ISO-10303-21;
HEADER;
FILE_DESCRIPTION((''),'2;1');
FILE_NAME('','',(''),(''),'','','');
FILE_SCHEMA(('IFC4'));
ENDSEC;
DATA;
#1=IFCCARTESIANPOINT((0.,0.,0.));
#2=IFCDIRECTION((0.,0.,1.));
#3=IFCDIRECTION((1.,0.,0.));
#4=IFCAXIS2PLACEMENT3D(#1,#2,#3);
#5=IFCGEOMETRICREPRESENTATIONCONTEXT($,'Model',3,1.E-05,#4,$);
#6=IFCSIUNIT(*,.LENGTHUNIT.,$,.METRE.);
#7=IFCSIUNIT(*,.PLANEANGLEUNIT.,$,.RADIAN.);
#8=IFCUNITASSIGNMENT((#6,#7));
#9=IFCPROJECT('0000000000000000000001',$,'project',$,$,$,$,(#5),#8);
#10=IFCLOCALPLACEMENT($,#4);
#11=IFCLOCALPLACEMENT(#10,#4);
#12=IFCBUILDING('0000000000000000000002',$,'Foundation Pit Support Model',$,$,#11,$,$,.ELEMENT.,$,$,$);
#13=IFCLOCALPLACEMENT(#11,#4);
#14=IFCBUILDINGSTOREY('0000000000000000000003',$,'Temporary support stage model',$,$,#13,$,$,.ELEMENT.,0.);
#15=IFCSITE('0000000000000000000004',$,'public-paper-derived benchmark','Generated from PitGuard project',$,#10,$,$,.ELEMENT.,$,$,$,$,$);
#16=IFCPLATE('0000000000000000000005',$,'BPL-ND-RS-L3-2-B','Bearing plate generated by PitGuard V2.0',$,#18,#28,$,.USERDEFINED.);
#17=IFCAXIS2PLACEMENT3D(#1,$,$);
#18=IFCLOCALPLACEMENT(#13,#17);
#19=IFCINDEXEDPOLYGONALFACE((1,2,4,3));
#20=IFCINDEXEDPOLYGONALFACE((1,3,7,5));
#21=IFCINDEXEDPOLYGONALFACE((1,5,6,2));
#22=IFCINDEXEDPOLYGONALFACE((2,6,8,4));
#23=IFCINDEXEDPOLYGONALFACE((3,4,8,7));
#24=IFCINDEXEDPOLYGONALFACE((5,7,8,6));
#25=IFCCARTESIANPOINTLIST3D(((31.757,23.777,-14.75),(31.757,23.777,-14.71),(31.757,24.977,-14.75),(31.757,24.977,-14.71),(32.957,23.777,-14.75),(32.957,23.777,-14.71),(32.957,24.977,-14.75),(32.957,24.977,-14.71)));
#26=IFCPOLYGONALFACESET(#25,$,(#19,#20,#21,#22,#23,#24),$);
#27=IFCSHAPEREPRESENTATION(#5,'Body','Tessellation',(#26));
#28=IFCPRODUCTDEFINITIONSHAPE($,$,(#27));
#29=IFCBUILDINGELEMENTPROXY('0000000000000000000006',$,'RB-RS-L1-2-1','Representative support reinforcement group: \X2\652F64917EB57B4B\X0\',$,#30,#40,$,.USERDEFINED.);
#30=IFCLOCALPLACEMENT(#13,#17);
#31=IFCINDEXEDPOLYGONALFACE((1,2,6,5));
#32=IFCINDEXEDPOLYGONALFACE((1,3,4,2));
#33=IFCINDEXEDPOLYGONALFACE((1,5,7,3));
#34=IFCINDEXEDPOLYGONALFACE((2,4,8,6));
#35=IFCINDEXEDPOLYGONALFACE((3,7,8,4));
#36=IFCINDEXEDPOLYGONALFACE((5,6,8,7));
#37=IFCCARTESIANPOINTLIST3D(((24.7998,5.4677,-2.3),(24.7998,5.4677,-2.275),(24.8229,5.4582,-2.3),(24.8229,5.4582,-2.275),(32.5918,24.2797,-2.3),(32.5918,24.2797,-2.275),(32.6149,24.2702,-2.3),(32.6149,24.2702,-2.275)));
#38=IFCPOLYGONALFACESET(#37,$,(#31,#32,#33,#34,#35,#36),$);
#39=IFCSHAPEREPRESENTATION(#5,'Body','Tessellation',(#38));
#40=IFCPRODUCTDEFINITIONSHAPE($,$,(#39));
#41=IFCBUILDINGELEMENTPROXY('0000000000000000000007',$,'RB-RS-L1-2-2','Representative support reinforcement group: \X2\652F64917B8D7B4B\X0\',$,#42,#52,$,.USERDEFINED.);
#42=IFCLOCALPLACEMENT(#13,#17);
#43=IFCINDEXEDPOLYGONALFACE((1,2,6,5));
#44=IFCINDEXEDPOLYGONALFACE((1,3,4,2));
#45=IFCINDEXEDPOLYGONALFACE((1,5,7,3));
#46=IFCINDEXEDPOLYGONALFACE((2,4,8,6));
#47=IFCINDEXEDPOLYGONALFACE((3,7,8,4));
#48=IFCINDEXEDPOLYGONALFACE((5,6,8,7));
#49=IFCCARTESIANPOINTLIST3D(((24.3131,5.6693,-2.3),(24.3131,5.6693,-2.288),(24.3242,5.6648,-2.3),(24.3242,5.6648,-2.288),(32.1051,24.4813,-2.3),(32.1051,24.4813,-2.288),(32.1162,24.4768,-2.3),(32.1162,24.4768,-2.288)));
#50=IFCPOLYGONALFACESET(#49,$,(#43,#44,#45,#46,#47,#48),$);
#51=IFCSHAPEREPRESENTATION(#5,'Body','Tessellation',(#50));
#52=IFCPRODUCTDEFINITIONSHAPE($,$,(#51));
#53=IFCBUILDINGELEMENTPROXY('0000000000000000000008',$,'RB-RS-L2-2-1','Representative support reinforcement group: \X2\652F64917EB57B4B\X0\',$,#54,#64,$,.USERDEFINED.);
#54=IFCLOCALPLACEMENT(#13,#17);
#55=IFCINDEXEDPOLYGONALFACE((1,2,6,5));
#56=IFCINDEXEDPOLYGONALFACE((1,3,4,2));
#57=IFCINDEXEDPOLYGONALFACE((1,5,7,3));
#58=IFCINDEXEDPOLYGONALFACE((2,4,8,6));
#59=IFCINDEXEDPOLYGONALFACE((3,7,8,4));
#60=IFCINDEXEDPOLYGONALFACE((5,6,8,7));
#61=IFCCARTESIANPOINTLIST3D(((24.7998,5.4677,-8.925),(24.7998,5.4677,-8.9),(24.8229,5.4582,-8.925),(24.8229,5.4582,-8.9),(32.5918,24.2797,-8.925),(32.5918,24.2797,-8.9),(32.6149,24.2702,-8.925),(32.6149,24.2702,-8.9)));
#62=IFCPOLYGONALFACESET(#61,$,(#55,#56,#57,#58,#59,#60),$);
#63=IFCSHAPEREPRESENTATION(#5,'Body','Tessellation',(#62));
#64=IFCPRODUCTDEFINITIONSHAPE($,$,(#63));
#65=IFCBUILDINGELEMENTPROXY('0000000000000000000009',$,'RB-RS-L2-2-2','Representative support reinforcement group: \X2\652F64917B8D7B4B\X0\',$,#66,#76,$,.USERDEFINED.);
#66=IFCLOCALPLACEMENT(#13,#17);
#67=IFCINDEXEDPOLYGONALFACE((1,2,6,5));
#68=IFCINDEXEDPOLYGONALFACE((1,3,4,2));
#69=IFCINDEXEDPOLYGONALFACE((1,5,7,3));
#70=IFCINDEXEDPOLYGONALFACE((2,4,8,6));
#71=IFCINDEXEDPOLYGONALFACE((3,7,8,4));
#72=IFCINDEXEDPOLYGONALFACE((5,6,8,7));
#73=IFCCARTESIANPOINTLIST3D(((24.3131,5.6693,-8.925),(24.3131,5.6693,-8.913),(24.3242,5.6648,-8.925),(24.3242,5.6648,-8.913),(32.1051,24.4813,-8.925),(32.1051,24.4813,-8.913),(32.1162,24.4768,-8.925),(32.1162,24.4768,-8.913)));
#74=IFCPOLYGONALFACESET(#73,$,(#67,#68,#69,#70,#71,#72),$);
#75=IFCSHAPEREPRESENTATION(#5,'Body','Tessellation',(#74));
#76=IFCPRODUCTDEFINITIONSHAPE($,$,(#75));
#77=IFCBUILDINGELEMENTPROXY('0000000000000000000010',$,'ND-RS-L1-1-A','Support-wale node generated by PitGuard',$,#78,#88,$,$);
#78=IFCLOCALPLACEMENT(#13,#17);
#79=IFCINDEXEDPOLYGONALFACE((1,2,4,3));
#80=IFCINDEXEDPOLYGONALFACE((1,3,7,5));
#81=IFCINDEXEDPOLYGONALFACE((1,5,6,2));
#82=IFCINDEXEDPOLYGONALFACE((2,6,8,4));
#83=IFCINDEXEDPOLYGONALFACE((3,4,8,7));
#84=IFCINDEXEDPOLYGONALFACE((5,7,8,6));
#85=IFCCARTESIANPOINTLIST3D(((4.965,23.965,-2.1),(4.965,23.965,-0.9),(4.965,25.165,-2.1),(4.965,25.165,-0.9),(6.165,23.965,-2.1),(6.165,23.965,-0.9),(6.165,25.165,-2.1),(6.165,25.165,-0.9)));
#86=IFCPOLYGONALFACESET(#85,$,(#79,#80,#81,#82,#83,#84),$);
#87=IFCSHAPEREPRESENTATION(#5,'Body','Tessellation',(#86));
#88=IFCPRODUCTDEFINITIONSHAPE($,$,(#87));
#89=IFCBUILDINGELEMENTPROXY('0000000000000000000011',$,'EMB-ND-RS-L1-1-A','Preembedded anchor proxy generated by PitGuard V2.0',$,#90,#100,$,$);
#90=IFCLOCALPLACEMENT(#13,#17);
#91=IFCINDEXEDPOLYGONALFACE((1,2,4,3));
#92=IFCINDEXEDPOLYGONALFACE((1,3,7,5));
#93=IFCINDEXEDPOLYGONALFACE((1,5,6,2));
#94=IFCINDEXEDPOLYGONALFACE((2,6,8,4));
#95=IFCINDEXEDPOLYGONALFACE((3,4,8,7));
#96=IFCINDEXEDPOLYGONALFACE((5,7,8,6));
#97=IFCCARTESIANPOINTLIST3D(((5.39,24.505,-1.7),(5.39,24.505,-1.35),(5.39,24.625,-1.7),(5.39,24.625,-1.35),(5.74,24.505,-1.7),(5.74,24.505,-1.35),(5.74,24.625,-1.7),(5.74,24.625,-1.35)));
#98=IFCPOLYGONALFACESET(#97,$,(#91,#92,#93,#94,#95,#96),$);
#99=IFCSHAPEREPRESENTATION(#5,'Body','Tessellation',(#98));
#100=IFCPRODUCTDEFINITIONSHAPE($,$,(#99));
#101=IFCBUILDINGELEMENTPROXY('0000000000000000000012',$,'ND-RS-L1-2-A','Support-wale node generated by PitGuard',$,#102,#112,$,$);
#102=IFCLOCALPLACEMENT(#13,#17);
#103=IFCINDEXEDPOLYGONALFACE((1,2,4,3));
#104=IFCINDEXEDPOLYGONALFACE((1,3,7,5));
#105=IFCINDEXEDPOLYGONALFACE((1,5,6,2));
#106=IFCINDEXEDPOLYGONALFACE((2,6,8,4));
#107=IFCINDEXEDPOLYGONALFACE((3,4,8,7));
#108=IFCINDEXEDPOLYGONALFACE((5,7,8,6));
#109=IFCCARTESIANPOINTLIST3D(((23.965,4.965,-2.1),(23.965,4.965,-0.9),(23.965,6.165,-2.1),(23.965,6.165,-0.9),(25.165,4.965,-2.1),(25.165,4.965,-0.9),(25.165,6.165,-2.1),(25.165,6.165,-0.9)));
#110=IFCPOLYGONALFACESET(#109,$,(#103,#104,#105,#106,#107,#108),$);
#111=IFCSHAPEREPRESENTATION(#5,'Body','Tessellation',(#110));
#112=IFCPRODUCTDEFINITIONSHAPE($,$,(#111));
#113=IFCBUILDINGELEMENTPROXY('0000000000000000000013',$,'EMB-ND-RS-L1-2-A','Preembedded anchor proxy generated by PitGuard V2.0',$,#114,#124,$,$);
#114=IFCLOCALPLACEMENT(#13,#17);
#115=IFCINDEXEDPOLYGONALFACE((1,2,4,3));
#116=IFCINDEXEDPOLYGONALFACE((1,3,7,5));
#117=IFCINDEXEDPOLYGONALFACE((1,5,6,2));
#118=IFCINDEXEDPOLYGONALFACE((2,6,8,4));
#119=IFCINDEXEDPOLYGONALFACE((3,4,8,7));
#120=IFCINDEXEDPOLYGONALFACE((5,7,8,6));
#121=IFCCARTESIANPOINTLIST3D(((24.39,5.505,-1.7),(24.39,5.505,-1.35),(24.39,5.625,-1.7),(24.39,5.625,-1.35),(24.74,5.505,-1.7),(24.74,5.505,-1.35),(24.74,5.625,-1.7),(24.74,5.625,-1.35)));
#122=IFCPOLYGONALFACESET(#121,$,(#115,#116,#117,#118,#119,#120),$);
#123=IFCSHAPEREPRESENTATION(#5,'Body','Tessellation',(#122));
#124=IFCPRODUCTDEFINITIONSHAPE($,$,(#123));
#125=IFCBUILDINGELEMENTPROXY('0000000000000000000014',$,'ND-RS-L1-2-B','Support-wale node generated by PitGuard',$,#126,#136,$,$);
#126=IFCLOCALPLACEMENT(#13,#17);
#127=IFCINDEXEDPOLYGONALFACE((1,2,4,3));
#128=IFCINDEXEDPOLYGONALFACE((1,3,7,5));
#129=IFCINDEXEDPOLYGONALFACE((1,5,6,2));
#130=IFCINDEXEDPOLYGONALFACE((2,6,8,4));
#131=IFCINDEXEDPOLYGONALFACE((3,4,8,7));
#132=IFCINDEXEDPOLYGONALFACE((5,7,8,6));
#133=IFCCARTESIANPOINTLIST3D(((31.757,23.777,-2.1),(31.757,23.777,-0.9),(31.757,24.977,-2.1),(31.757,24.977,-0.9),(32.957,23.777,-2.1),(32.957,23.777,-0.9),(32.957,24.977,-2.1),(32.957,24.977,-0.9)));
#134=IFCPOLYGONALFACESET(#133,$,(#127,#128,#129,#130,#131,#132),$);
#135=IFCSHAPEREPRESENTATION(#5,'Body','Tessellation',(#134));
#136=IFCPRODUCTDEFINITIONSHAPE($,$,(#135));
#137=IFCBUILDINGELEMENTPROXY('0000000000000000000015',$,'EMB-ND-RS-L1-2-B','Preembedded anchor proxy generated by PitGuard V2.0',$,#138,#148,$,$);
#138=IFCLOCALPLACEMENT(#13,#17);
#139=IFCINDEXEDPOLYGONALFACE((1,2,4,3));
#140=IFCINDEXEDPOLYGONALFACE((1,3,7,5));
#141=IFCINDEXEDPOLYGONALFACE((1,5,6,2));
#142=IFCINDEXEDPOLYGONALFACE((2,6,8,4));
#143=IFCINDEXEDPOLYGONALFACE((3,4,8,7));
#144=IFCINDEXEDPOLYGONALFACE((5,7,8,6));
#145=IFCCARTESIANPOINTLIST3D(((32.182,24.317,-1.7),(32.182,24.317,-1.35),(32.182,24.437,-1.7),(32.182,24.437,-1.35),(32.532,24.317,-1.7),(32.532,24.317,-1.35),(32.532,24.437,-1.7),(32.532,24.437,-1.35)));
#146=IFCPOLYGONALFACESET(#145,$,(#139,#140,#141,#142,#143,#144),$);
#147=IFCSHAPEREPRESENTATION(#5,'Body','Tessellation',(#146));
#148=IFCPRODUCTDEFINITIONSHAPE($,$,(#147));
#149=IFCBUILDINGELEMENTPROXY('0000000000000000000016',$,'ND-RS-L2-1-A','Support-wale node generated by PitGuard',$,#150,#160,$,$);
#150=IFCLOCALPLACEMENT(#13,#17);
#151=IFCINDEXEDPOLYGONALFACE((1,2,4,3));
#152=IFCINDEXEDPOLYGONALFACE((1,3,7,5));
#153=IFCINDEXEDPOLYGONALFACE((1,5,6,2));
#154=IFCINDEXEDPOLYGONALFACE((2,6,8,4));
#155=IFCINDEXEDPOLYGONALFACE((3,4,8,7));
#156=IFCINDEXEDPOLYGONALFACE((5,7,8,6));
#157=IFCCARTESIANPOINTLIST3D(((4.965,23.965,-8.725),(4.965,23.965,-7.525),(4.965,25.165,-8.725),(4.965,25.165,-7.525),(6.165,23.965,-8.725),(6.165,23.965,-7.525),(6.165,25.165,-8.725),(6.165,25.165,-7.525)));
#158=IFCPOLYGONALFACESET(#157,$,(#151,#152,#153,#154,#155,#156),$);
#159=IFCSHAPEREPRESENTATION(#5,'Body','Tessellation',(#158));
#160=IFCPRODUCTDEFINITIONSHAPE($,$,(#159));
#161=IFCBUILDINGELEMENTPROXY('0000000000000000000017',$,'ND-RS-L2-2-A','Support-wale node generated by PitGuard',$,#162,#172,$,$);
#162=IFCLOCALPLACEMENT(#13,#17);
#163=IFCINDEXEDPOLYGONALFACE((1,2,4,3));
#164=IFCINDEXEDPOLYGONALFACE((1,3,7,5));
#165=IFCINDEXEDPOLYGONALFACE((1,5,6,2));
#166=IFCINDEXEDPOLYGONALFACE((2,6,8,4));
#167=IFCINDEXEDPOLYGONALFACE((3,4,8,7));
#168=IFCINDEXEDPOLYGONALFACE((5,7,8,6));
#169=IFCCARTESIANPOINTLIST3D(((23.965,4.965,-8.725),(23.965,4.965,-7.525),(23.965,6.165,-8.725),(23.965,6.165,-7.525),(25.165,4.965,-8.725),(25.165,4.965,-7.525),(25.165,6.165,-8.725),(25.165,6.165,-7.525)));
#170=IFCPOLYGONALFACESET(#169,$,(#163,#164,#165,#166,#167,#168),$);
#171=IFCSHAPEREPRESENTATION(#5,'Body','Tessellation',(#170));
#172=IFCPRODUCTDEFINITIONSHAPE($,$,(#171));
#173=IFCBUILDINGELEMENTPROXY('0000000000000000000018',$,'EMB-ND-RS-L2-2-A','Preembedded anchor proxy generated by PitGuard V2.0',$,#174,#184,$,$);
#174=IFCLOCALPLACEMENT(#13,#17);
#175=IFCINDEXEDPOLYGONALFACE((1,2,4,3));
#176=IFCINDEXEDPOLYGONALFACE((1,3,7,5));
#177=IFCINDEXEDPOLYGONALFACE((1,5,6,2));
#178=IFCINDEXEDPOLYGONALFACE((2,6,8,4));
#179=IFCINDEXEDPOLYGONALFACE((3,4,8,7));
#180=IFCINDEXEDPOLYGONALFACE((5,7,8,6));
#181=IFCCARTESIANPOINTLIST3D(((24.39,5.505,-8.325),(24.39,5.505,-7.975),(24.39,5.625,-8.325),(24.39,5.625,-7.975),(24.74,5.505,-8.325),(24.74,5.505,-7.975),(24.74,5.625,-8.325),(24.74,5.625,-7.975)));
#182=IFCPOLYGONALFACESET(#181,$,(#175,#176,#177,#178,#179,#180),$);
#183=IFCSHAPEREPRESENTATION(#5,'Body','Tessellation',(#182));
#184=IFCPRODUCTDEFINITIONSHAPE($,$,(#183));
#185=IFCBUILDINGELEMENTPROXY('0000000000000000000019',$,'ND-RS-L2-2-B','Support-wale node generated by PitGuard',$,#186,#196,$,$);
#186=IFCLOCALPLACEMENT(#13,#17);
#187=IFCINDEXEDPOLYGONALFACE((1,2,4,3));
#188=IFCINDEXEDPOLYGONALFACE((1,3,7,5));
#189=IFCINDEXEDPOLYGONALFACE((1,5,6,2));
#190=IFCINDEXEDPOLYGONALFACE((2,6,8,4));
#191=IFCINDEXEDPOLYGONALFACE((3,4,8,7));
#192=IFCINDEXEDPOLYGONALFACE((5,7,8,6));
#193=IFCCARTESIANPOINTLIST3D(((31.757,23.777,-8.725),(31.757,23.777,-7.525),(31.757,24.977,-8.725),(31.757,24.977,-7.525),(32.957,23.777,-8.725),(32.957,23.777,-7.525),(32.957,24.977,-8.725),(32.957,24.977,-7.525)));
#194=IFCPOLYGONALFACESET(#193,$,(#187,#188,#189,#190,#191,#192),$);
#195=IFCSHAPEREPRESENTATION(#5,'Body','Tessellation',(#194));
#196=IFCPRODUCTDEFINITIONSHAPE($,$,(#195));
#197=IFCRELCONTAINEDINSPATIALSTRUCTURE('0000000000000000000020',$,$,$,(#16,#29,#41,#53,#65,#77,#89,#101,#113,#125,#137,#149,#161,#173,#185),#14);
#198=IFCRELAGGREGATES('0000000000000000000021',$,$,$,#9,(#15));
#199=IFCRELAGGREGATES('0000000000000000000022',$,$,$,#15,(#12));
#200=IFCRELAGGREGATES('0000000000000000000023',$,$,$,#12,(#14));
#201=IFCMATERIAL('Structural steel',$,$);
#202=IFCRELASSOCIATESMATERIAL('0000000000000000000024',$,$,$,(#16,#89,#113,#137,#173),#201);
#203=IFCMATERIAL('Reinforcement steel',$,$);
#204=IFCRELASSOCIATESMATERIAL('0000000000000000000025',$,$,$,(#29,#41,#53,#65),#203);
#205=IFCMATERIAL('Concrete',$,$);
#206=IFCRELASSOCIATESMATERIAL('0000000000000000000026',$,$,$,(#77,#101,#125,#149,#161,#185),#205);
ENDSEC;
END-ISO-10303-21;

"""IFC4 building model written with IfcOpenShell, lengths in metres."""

from ifc_helpers import new_model, si_unit, frame, origin_with_axes, origin_2d, place, context, project, spatial, rectangle, extrude, material, element, save


model = new_model("IFC4")

# Units and contexts
model_context = context("Model", 3, precision=1e-05, world=origin_with_axes())
ifc_project = project(units=[si_unit("LENGTHUNIT", "METRE"), si_unit("PLANEANGLEUNIT", "RADIAN")], contexts=[model_context])

# Site, building, storey
site_placement = place(None, origin_with_axes())
site = spatial("IfcSite", under=ifc_project, at=site_placement, Name="public-paper-derived benchmark", Description="Generated from PitGuard project", CompositionType="ELEMENT")
building_placement = place(site_placement, origin_with_axes())
building = spatial("IfcBuilding", under=site, at=building_placement, Name="Foundation Pit Support Model", CompositionType="ELEMENT")
storey_placement = place(building_placement, origin_with_axes())
storey = spatial("IfcBuildingStorey", under=building, at=storey_placement, Name="Temporary support stage model", CompositionType="ELEMENT", Elevation=0.0)

# Shared definitions
ifc_material_1 = material(Name="Concrete")

# Plate
ifc_material_2 = material(Name="Structural steel")
for number, where, z_axis, x_axis, name in (
    (1, (32.357, 24.377, -14.75), (0.0, 0.0, 1.0), (1.0, 0.0, 0.0), "BPL-ND-RS-L3-2-B"),
):
    element("IfcPlate", number, at=place(storey_placement, frame(where, z_axis=z_axis, x_axis=x_axis)), inside=storey, material=ifc_material_2, Name=name, Description="Bearing plate generated by PitGuard V2.0", PredefinedType="USERDEFINED", context=model_context, shape_type="SweptSolid", body=[
        extrude(rectangle(XDim=1.2, YDim=1.2, at=origin_2d()), origin_with_axes(), (0.0, 0.0, 1.0), 0.04),
    ])

# Building element proxies
ifc_material_3 = material(Name="Reinforcement steel")
proxy_1_placement = place(storey_placement, frame((28.7074, 14.869, -2.3), z_axis=(0.0, 0.0, 1.0), x_axis=(0.382676, 0.923883, 0.0)))
element("IfcBuildingElementProxy", 2, at=proxy_1_placement, inside=storey, material=ifc_material_3, Name="RB-RS-L1-2-1", Description="Representative support reinforcement group: 支撑纵筋", PredefinedType="USERDEFINED", context=model_context, shape_type="SweptSolid", body=[
    extrude(rectangle(XDim=20.3619, YDim=0.025, at=origin_2d()), origin_with_axes(), (0.0, 0.0, 1.0), 0.025),
])
proxy_2_placement = place(storey_placement, frame((28.2146, 15.073, -2.3), z_axis=(0.0, 0.0, 1.0), x_axis=(0.382676, 0.923883, 0.0)))
element("IfcBuildingElementProxy", 3, at=proxy_2_placement, inside=storey, material=ifc_material_3, Name="RB-RS-L1-2-2", Description="Representative support reinforcement group: 支撑箍筋", PredefinedType="USERDEFINED", context=model_context, shape_type="SweptSolid", body=[
    extrude(rectangle(XDim=20.3619, YDim=0.012, at=origin_2d()), origin_with_axes(), (0.0, 0.0, 1.0), 0.012),
])
proxy_3_placement = place(storey_placement, frame((28.7074, 14.869, -8.925), z_axis=(0.0, 0.0, 1.0), x_axis=(0.382676, 0.923883, 0.0)))
element("IfcBuildingElementProxy", 4, at=proxy_3_placement, inside=storey, material=ifc_material_3, Name="RB-RS-L2-2-1", Description="Representative support reinforcement group: 支撑纵筋", PredefinedType="USERDEFINED", context=model_context, shape_type="SweptSolid", body=[
    extrude(rectangle(XDim=20.3619, YDim=0.025, at=origin_2d()), origin_with_axes(), (0.0, 0.0, 1.0), 0.025),
])
proxy_4_placement = place(storey_placement, frame((28.2146, 15.073, -8.925), z_axis=(0.0, 0.0, 1.0), x_axis=(0.382676, 0.923883, 0.0)))
element("IfcBuildingElementProxy", 5, at=proxy_4_placement, inside=storey, material=ifc_material_3, Name="RB-RS-L2-2-2", Description="Representative support reinforcement group: 支撑箍筋", PredefinedType="USERDEFINED", context=model_context, shape_type="SweptSolid", body=[
    extrude(rectangle(XDim=20.3619, YDim=0.012, at=origin_2d()), origin_with_axes(), (0.0, 0.0, 1.0), 0.012),
])
proxy_5_placement = place(storey_placement, frame((5.565, 24.565, -2.1), z_axis=(0.0, 0.0, 1.0), x_axis=(1.0, 0.0, 0.0)))
element("IfcBuildingElementProxy", 6, at=proxy_5_placement, inside=storey, material=ifc_material_1, Name="ND-RS-L1-1-A", Description="Support-wale node generated by PitGuard", context=model_context, shape_type="SweptSolid", body=[
    extrude(rectangle(XDim=1.2, YDim=1.2, at=origin_2d()), origin_with_axes(), (0.0, 0.0, 1.0), 1.2),
])
proxy_6_placement = place(storey_placement, frame((5.565, 24.565, -1.7), z_axis=(0.0, 0.0, 1.0), x_axis=(1.0, 0.0, 0.0)))
element("IfcBuildingElementProxy", 7, at=proxy_6_placement, inside=storey, material=ifc_material_2, Name="EMB-ND-RS-L1-1-A", Description="Preembedded anchor proxy generated by PitGuard V2.0", context=model_context, shape_type="SweptSolid", body=[
    extrude(rectangle(XDim=0.35, YDim=0.12, at=origin_2d()), origin_with_axes(), (0.0, 0.0, 1.0), 0.35),
])
proxy_7_placement = place(storey_placement, frame((24.565, 5.565, -2.1), z_axis=(0.0, 0.0, 1.0), x_axis=(1.0, 0.0, 0.0)))
element("IfcBuildingElementProxy", 8, at=proxy_7_placement, inside=storey, material=ifc_material_1, Name="ND-RS-L1-2-A", Description="Support-wale node generated by PitGuard", context=model_context, shape_type="SweptSolid", body=[
    extrude(rectangle(XDim=1.2, YDim=1.2, at=origin_2d()), origin_with_axes(), (0.0, 0.0, 1.0), 1.2),
])
proxy_8_placement = place(storey_placement, frame((24.565, 5.565, -1.7), z_axis=(0.0, 0.0, 1.0), x_axis=(1.0, 0.0, 0.0)))
element("IfcBuildingElementProxy", 9, at=proxy_8_placement, inside=storey, material=ifc_material_2, Name="EMB-ND-RS-L1-2-A", Description="Preembedded anchor proxy generated by PitGuard V2.0", context=model_context, shape_type="SweptSolid", body=[
    extrude(rectangle(XDim=0.35, YDim=0.12, at=origin_2d()), origin_with_axes(), (0.0, 0.0, 1.0), 0.35),
])
proxy_9_placement = place(storey_placement, frame((32.357, 24.377, -2.1), z_axis=(0.0, 0.0, 1.0), x_axis=(1.0, 0.0, 0.0)))
element("IfcBuildingElementProxy", 10, at=proxy_9_placement, inside=storey, material=ifc_material_1, Name="ND-RS-L1-2-B", Description="Support-wale node generated by PitGuard", context=model_context, shape_type="SweptSolid", body=[
    extrude(rectangle(XDim=1.2, YDim=1.2, at=origin_2d()), origin_with_axes(), (0.0, 0.0, 1.0), 1.2),
])
proxy_10_placement = place(storey_placement, frame((32.357, 24.377, -1.7), z_axis=(0.0, 0.0, 1.0), x_axis=(1.0, 0.0, 0.0)))
element("IfcBuildingElementProxy", 11, at=proxy_10_placement, inside=storey, material=ifc_material_2, Name="EMB-ND-RS-L1-2-B", Description="Preembedded anchor proxy generated by PitGuard V2.0", context=model_context, shape_type="SweptSolid", body=[
    extrude(rectangle(XDim=0.35, YDim=0.12, at=origin_2d()), origin_with_axes(), (0.0, 0.0, 1.0), 0.35),
])
for number, where, z_axis, x_axis, name in (
    (12, (5.565, 24.565, -8.725), (0.0, 0.0, 1.0), (1.0, 0.0, 0.0), "ND-RS-L2-1-A"),
    (13, (24.565, 5.565, -8.725), (0.0, 0.0, 1.0), (1.0, 0.0, 0.0), "ND-RS-L2-2-A"),
):
    element("IfcBuildingElementProxy", number, at=place(storey_placement, frame(where, z_axis=z_axis, x_axis=x_axis)), inside=storey, material=ifc_material_1, Name=name, Description="Support-wale node generated by PitGuard", context=model_context, shape_type="SweptSolid", body=[
        extrude(rectangle(XDim=1.2, YDim=1.2, at=origin_2d()), origin_with_axes(), (0.0, 0.0, 1.0), 1.2),
    ])
proxy_11_placement = place(storey_placement, frame((24.565, 5.565, -8.325), z_axis=(0.0, 0.0, 1.0), x_axis=(1.0, 0.0, 0.0)))
element("IfcBuildingElementProxy", 14, at=proxy_11_placement, inside=storey, material=ifc_material_2, Name="EMB-ND-RS-L2-2-A", Description="Preembedded anchor proxy generated by PitGuard V2.0", context=model_context, shape_type="SweptSolid", body=[
    extrude(rectangle(XDim=0.35, YDim=0.12, at=origin_2d()), origin_with_axes(), (0.0, 0.0, 1.0), 0.35),
])
proxy_12_placement = place(storey_placement, frame((32.357, 24.377, -8.725), z_axis=(0.0, 0.0, 1.0), x_axis=(1.0, 0.0, 0.0)))
element("IfcBuildingElementProxy", 15, at=proxy_12_placement, inside=storey, material=ifc_material_1, Name="ND-RS-L2-2-B", Description="Support-wale node generated by PitGuard", context=model_context, shape_type="SweptSolid", body=[
    extrude(rectangle(XDim=1.2, YDim=1.2, at=origin_2d()), origin_with_axes(), (0.0, 0.0, 1.0), 1.2),
])

save(model, "model.ifc")
